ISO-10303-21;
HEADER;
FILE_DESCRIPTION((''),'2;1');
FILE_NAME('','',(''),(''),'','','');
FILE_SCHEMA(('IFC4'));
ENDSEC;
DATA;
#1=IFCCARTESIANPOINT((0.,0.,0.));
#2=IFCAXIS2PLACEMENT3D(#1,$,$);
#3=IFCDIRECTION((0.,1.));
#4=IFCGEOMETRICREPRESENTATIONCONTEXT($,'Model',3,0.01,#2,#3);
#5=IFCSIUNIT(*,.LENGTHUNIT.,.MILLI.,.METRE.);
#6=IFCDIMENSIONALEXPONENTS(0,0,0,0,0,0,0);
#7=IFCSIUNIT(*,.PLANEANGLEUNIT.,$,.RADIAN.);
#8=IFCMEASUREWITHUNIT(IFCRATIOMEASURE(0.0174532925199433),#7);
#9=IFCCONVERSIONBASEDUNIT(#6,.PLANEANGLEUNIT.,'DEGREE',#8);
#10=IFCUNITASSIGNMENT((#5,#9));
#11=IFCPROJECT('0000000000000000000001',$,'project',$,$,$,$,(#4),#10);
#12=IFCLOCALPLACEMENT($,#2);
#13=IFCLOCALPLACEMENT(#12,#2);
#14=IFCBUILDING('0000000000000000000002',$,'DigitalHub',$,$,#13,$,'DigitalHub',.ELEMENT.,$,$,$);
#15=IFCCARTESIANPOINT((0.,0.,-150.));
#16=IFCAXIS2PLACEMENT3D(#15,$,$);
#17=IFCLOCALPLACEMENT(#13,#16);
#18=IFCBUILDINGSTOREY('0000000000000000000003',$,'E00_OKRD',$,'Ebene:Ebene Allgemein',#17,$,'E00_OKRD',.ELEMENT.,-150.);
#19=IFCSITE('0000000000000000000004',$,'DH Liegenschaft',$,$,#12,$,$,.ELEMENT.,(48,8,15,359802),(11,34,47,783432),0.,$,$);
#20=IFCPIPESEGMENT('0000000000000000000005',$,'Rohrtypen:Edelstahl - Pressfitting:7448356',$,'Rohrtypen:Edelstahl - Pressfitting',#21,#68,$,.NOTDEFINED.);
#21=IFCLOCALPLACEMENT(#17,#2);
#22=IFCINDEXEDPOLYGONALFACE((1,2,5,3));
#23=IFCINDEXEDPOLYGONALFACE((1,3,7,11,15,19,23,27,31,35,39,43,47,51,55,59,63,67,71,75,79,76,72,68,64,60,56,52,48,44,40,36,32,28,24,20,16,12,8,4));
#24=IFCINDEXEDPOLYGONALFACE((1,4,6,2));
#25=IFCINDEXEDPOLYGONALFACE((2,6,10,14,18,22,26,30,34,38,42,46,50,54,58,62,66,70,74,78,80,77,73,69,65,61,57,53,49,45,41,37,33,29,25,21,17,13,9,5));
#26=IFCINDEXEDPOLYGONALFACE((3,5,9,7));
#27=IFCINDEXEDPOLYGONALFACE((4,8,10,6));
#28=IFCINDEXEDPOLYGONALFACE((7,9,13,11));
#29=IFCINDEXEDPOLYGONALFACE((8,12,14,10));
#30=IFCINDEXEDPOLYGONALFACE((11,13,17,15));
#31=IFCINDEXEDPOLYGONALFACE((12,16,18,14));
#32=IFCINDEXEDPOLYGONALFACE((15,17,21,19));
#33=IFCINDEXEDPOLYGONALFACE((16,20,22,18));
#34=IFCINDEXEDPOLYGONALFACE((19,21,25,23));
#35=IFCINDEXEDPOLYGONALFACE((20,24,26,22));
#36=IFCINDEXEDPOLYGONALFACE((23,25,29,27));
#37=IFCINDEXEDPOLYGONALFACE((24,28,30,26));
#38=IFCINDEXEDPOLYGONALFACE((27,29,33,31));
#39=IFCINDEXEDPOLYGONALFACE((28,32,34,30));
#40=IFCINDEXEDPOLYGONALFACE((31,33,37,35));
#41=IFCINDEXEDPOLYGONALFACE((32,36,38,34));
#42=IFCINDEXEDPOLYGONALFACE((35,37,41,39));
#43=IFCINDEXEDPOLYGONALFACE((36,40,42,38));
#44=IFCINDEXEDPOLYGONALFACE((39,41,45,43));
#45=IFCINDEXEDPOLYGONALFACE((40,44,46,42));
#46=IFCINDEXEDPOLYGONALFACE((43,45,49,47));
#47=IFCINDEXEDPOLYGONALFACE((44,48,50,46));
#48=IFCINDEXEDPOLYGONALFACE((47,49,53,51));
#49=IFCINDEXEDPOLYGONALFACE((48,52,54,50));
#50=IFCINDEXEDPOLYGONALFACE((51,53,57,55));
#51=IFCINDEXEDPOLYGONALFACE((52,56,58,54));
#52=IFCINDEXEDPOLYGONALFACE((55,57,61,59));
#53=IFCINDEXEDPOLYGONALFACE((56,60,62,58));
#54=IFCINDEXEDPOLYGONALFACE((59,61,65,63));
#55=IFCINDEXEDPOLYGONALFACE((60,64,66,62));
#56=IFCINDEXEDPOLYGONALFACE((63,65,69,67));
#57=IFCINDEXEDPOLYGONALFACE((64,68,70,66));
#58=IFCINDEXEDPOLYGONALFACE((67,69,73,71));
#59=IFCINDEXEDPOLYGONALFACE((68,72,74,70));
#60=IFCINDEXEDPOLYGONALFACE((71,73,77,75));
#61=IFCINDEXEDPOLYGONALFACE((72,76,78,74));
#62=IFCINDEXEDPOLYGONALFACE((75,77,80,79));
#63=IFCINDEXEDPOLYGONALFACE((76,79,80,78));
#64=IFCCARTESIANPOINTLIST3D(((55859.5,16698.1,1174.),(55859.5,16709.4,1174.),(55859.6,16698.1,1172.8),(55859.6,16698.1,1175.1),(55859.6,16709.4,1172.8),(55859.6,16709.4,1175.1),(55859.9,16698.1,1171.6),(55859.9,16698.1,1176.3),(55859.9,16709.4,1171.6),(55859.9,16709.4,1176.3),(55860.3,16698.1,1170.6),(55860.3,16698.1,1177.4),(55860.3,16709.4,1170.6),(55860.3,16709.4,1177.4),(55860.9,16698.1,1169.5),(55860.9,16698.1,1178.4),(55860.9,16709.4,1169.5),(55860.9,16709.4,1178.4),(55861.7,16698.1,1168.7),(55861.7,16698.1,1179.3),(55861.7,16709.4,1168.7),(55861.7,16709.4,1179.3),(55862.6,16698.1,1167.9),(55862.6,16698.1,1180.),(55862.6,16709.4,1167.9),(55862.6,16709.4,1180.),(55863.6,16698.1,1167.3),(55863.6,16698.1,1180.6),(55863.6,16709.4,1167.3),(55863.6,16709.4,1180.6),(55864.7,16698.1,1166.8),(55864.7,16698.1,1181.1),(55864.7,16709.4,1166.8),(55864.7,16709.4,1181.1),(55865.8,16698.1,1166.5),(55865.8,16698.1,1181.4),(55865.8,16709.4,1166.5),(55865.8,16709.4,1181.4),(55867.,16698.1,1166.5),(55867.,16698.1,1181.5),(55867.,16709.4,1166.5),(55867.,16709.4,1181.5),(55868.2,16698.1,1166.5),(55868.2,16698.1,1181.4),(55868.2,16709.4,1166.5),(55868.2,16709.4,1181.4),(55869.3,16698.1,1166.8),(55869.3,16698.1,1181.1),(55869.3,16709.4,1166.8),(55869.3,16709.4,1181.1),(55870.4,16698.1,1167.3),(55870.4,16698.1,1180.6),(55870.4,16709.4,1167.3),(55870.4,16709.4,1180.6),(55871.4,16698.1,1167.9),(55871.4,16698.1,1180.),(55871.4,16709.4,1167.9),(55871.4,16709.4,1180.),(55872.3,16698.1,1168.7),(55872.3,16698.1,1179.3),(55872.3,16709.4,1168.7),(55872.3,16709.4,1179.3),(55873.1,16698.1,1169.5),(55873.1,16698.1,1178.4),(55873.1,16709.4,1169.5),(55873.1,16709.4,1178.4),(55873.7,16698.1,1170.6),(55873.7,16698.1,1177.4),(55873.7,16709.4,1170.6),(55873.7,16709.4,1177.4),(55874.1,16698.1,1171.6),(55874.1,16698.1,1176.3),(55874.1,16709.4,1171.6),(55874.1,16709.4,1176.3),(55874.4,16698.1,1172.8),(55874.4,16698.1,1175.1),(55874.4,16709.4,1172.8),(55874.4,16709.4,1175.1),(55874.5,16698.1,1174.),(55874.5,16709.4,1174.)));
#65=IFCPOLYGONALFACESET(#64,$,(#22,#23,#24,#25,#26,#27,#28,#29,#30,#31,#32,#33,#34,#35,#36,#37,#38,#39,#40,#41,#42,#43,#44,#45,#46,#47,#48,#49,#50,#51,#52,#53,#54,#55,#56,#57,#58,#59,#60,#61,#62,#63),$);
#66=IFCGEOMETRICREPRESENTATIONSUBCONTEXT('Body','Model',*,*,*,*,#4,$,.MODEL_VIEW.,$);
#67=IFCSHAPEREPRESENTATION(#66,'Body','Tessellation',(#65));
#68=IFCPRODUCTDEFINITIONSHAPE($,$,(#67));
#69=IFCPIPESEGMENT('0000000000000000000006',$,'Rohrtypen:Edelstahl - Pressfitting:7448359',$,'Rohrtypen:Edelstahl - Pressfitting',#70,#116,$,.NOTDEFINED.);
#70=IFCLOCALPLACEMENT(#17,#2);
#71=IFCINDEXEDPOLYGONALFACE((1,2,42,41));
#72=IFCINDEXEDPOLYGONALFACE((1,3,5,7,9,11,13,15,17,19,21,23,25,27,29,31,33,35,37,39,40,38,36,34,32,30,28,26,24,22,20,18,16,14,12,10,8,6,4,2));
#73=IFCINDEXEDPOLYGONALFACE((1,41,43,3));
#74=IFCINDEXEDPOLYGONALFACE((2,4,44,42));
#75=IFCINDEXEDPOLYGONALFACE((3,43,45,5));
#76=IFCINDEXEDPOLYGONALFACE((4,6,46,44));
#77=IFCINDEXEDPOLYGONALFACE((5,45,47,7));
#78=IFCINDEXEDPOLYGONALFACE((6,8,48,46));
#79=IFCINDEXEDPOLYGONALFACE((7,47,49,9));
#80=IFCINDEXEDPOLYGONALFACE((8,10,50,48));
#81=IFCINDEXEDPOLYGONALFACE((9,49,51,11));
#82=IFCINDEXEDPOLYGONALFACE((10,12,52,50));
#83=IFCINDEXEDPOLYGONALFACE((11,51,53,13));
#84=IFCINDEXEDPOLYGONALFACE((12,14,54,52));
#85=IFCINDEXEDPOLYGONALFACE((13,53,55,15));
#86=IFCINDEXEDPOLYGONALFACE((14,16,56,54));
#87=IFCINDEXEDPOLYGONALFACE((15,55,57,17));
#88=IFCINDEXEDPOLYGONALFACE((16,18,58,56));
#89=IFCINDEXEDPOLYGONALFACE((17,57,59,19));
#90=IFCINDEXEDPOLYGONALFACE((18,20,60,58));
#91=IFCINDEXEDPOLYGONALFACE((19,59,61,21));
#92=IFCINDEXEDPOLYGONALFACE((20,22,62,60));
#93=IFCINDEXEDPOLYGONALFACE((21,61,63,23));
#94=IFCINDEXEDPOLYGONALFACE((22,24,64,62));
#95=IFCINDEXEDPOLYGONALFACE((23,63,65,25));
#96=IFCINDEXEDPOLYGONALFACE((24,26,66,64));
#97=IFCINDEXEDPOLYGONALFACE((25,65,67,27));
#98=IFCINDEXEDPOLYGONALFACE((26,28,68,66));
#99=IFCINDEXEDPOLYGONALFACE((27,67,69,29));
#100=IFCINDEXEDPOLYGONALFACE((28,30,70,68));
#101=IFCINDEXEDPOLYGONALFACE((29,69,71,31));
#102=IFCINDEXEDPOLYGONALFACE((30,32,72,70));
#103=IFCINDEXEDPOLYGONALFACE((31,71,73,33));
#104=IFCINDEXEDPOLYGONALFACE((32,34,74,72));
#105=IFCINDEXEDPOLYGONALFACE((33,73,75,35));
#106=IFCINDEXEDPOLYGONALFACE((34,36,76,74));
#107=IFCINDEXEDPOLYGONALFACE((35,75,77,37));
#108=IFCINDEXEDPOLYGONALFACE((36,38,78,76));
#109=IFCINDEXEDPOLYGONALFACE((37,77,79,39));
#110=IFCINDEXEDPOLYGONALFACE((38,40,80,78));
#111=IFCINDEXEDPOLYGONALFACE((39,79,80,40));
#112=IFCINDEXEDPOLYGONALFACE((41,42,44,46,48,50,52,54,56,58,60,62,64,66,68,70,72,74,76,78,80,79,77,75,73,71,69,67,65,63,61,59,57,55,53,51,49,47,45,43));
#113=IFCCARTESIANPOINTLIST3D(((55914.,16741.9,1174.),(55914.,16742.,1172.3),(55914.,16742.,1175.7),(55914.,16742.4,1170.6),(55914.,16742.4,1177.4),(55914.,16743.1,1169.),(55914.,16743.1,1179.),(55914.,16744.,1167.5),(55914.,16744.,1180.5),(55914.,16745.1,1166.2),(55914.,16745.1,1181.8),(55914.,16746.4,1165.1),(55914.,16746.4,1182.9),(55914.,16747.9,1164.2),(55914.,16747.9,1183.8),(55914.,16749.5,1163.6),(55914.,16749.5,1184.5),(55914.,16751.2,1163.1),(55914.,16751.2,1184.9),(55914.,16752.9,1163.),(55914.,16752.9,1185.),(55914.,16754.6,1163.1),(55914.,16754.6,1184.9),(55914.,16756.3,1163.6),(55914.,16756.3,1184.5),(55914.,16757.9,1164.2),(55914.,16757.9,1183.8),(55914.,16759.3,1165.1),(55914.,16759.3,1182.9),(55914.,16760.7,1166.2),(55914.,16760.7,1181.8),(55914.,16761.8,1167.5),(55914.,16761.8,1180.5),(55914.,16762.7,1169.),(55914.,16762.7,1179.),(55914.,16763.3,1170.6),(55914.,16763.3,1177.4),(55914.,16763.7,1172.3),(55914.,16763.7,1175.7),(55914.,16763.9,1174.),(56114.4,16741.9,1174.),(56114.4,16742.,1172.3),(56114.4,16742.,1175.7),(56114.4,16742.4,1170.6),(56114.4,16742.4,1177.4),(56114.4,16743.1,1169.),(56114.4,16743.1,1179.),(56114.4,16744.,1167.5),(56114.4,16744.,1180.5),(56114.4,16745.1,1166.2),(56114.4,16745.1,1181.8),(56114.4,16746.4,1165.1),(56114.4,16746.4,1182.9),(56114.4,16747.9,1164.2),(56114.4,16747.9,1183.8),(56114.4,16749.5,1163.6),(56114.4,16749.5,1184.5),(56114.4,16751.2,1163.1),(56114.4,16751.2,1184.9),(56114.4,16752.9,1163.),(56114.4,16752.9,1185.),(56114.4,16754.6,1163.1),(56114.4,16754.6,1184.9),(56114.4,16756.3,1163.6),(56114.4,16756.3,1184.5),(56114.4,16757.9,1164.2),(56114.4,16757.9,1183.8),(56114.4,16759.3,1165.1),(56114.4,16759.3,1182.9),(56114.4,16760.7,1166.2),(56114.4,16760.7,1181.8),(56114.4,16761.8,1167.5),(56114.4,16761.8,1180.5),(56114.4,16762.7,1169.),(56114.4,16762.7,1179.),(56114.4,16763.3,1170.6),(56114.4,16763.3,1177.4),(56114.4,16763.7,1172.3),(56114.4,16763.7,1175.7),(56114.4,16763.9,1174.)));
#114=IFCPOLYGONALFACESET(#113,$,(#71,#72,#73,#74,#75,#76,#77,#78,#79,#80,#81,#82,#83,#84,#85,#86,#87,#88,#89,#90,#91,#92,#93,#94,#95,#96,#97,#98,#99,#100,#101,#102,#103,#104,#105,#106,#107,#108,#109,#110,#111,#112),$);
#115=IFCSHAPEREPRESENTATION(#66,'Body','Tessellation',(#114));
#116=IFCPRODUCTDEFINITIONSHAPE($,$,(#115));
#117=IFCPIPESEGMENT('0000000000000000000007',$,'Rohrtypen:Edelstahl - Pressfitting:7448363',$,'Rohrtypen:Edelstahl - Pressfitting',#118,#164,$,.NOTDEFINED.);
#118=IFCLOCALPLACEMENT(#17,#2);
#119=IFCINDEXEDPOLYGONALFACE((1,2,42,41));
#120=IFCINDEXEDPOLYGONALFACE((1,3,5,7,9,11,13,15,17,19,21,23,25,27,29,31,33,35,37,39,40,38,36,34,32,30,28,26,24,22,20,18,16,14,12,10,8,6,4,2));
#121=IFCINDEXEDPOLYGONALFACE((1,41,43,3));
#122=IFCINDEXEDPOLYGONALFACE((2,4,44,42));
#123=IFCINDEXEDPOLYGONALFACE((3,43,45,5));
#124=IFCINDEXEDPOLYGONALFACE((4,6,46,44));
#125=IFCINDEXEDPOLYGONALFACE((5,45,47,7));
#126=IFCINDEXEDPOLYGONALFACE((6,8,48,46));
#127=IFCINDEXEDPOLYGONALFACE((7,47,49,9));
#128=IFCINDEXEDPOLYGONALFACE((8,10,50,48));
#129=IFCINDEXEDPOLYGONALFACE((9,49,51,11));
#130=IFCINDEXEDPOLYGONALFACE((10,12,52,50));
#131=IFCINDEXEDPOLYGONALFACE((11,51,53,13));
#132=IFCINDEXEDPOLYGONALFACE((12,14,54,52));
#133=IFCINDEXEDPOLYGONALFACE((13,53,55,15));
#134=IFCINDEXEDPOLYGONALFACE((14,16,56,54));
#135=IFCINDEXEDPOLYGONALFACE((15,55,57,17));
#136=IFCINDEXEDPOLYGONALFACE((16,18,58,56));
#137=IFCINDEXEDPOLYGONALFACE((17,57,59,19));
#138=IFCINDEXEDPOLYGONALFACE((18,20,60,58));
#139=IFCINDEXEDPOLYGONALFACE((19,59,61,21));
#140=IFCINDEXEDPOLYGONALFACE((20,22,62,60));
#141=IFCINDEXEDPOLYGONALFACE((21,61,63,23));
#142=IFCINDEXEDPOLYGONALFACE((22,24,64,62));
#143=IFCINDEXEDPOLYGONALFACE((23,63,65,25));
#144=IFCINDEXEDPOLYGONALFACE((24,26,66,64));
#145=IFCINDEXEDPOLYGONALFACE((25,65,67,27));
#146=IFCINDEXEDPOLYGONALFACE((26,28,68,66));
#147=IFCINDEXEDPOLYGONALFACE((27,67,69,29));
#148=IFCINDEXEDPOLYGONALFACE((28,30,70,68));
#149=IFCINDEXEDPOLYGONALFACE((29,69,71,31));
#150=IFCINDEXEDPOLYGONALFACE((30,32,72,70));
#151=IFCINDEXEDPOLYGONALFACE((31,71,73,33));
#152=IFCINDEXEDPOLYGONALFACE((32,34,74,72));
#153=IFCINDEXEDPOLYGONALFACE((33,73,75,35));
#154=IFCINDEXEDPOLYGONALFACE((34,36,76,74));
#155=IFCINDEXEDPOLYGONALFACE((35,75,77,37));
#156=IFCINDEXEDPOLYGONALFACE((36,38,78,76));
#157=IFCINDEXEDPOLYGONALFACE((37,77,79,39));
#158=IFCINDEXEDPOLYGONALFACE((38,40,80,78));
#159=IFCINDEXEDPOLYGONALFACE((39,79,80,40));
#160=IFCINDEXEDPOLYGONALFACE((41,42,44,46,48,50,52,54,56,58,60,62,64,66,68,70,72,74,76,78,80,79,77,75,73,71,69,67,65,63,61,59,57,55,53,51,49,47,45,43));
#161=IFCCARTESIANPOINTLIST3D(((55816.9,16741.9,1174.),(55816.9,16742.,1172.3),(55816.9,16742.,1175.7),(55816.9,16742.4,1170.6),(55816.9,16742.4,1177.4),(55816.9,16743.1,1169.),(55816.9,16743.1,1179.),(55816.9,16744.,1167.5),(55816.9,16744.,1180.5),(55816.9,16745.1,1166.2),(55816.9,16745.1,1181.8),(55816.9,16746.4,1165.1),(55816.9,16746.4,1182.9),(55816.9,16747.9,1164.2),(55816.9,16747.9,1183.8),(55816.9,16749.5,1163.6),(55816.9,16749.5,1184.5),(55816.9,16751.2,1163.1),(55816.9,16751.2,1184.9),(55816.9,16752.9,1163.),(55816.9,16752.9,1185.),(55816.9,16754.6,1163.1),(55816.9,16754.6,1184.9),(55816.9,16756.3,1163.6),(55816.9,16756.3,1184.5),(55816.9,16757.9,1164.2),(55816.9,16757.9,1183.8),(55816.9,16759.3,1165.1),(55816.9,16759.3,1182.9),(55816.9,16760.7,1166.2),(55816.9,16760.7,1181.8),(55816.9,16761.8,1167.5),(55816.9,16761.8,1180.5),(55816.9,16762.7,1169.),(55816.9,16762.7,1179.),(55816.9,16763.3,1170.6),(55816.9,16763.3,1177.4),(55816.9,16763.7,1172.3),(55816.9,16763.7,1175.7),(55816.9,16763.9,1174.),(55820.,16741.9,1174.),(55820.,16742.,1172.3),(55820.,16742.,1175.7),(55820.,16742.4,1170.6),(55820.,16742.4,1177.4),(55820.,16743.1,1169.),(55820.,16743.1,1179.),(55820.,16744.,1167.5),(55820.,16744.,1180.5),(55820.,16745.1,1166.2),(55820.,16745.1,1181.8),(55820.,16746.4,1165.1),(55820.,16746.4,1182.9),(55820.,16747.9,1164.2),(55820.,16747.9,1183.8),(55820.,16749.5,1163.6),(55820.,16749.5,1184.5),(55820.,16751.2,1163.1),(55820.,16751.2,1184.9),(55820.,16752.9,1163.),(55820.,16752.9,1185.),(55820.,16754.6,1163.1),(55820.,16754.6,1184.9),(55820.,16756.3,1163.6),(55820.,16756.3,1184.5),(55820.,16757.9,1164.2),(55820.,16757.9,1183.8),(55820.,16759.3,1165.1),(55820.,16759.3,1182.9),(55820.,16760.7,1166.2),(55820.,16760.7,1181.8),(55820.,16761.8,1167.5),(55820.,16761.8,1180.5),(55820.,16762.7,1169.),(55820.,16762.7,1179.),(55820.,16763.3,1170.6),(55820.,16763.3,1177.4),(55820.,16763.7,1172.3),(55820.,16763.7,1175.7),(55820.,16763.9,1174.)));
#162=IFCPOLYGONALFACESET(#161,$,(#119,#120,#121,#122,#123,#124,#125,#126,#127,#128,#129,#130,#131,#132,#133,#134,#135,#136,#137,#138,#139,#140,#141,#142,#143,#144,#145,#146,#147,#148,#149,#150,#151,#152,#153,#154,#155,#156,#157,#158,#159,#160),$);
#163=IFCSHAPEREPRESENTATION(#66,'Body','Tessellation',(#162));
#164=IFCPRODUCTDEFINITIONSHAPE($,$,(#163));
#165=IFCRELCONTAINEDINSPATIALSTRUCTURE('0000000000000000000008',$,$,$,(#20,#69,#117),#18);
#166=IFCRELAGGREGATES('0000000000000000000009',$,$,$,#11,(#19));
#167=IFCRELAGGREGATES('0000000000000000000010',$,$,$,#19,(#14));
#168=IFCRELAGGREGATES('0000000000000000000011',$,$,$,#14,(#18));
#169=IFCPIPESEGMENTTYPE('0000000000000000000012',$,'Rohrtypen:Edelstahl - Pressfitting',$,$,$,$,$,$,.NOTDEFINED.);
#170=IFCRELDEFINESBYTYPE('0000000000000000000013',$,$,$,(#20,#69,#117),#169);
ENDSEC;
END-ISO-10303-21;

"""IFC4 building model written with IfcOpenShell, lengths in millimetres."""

from ifc_helpers import new_model, entity, si_unit, converted_unit, direction, frame, origin, place, context, subcontext, project, spatial, indexed_curve, outline, extrude, type_object, element, save


model = new_model("IFC4")

# Units and contexts
model_context = context("Model", 3, precision=0.01, world=origin(), true_north=direction((0.0, 1.0)))
body_context = subcontext(model_context, "Body", "Model", "MODEL_VIEW")
ifc_project = project(units=[si_unit("LENGTHUNIT", "METRE", prefix="MILLI"), converted_unit("PLANEANGLEUNIT", "DEGREE", entity("IfcRatioMeasure", 0.0174532925199433), si_unit("PLANEANGLEUNIT", "RADIAN"), dimensions=[0, 0, 0, 0, 0, 0, 0])], contexts=[model_context])

# Site, building, storey
site_placement = place(None, origin())
site = spatial("IfcSite", under=ifc_project, at=site_placement, Name="DH Liegenschaft", CompositionType="ELEMENT", RefLatitude=(48, 8, 15, 359802), RefLongitude=(11, 34, 47, 783432), RefElevation=0.0)
building_placement = place(site_placement, origin())
building = spatial("IfcBuilding", under=site, at=building_placement, Name="DigitalHub", LongName="DigitalHub", CompositionType="ELEMENT")
storey_placement = place(building_placement, frame((0.0, 0.0, -150.0)))
storey = spatial("IfcBuildingStorey", under=building, at=storey_placement, Name="E00_OKRD", ObjectType="Ebene:Ebene Allgemein", LongName="E00_OKRD", CompositionType="ELEMENT", Elevation=-150.0)

# Pipe segments
pipe_segment_type_1 = type_object("IfcPipeSegmentType", Name="Rohrtypen:Edelstahl - Pressfitting", PredefinedType="NOTDEFINED")
pipe_segment_1_placement = place(storey_placement, frame((55857.9, 16698.1, 1164.9)))
element("IfcPipeSegment", 1, at=pipe_segment_1_placement, inside=storey, type_object=pipe_segment_type_1, Name="Rohrtypen:Edelstahl - Pressfitting:7448356", ObjectType="Rohrtypen:Edelstahl - Pressfitting", PredefinedType="NOTDEFINED", context=body_context, shape_type="SweptSolid", body=[
    extrude(outline(indexed_curve([(7.5, 0.0), (7.4, 1.2), (7.1, 2.3), (6.7, 3.4), (6.1, 4.4), (5.3, 5.3), (4.4, 6.1), (3.4, 6.7), (2.3, 7.1), (1.2, 7.4), (0.0, 7.5), (-1.2, 7.4), (-2.3, 7.1), (-3.4, 6.7), (-4.4, 6.1), (-5.3, 5.3), (-6.1, 4.4), (-6.7, 3.4), (-7.1, 2.3), (-7.4, 1.2), (-7.5, 0.0), (-7.4, -1.2), (-7.1, -2.3), (-6.7, -3.4), (-6.1, -4.4), (-5.3, -5.3), (-4.4, -6.1), (-3.4, -6.7), (-2.3, -7.1), (-1.2, -7.4), (0.0, -7.5), (1.2, -7.4), (2.3, -7.1), (3.4, -6.7), (4.4, -6.1), (5.3, -5.3), (6.1, -4.4), (6.7, -3.4), (7.1, -2.3), (7.4, -1.2), (7.5, 0.0)], self_intersect=False)), frame((9.1, 0.0, 9.1), z_axis=(-0.000001, 1.0, 0.0), x_axis=(-1.0, -0.000001, 0.0)), (0.0, 0.0, 1.0), 11.3),
])
pipe_segment_2_placement = place(storey_placement, frame((55914.0, 16740.3, 1161.4)))
element("IfcPipeSegment", 2, at=pipe_segment_2_placement, inside=storey, type_object=pipe_segment_type_1, Name="Rohrtypen:Edelstahl - Pressfitting:7448359", ObjectType="Rohrtypen:Edelstahl - Pressfitting", PredefinedType="NOTDEFINED", context=body_context, shape_type="SweptSolid", body=[
    extrude(outline(indexed_curve([(11.0, 0.0), (10.9, 1.7), (10.5, 3.4), (9.8, 5.0), (8.9, 6.5), (7.8, 7.8), (6.5, 8.9), (5.0, 9.8), (3.4, 10.5), (1.7, 10.9), (0.0, 11.0), (-1.7, 10.9), (-3.4, 10.5), (-5.0, 9.8), (-6.5, 8.9), (-7.8, 7.8), (-8.9, 6.5), (-9.8, 5.0), (-10.5, 3.4), (-10.9, 1.7), (-11.0, 0.0), (-10.9, -1.7), (-10.5, -3.4), (-9.8, -5.0), (-8.9, -6.5), (-7.8, -7.8), (-6.5, -8.9), (-5.0, -9.8), (-3.4, -10.5), (-1.7, -10.9), (0.0, -11.0), (1.7, -10.9), (3.4, -10.5), (5.0, -9.8), (6.5, -8.9), (7.8, -7.8), (8.9, -6.5), (9.8, -5.0), (10.5, -3.4), (10.9, -1.7), (11.0, 0.0)], self_intersect=False)), frame((0.0, 12.6, 12.6), z_axis=(1.0, 0.000002, 0.0), x_axis=(-0.000002, 1.0, 0.0)), (0.0, 0.0, 1.0), 200.3),
])
pipe_segment_3_placement = place(storey_placement, frame((55816.9, 16740.3, 1161.4)))
element("IfcPipeSegment", 3, at=pipe_segment_3_placement, inside=storey, type_object=pipe_segment_type_1, Name="Rohrtypen:Edelstahl - Pressfitting:7448363", ObjectType="Rohrtypen:Edelstahl - Pressfitting", PredefinedType="NOTDEFINED", context=body_context, shape_type="SweptSolid", body=[
    extrude(outline(indexed_curve([(11.0, 0.0), (10.9, 1.7), (10.5, 3.4), (9.8, 5.0), (8.9, 6.5), (7.8, 7.8), (6.5, 8.9), (5.0, 9.8), (3.4, 10.5), (1.7, 10.9), (0.0, 11.0), (-1.7, 10.9), (-3.4, 10.5), (-5.0, 9.8), (-6.5, 8.9), (-7.8, 7.8), (-8.9, 6.5), (-9.8, 5.0), (-10.5, 3.4), (-10.9, 1.7), (-11.0, 0.0), (-10.9, -1.7), (-10.5, -3.4), (-9.8, -5.0), (-8.9, -6.5), (-7.8, -7.8), (-6.5, -8.9), (-5.0, -9.8), (-3.4, -10.5), (-1.7, -10.9), (0.0, -11.0), (1.7, -10.9), (3.4, -10.5), (5.0, -9.8), (6.5, -8.9), (7.8, -7.8), (8.9, -6.5), (9.8, -5.0), (10.5, -3.4), (10.9, -1.7), (11.0, 0.0)], self_intersect=False)), frame((0.0, 12.6, 12.6), z_axis=(1.0, 0.000027, 0.0), x_axis=(-0.000027, 1.0, 0.0)), (0.0, 0.0, 1.0), 3.2),
])

save(model, "model.ifc")
